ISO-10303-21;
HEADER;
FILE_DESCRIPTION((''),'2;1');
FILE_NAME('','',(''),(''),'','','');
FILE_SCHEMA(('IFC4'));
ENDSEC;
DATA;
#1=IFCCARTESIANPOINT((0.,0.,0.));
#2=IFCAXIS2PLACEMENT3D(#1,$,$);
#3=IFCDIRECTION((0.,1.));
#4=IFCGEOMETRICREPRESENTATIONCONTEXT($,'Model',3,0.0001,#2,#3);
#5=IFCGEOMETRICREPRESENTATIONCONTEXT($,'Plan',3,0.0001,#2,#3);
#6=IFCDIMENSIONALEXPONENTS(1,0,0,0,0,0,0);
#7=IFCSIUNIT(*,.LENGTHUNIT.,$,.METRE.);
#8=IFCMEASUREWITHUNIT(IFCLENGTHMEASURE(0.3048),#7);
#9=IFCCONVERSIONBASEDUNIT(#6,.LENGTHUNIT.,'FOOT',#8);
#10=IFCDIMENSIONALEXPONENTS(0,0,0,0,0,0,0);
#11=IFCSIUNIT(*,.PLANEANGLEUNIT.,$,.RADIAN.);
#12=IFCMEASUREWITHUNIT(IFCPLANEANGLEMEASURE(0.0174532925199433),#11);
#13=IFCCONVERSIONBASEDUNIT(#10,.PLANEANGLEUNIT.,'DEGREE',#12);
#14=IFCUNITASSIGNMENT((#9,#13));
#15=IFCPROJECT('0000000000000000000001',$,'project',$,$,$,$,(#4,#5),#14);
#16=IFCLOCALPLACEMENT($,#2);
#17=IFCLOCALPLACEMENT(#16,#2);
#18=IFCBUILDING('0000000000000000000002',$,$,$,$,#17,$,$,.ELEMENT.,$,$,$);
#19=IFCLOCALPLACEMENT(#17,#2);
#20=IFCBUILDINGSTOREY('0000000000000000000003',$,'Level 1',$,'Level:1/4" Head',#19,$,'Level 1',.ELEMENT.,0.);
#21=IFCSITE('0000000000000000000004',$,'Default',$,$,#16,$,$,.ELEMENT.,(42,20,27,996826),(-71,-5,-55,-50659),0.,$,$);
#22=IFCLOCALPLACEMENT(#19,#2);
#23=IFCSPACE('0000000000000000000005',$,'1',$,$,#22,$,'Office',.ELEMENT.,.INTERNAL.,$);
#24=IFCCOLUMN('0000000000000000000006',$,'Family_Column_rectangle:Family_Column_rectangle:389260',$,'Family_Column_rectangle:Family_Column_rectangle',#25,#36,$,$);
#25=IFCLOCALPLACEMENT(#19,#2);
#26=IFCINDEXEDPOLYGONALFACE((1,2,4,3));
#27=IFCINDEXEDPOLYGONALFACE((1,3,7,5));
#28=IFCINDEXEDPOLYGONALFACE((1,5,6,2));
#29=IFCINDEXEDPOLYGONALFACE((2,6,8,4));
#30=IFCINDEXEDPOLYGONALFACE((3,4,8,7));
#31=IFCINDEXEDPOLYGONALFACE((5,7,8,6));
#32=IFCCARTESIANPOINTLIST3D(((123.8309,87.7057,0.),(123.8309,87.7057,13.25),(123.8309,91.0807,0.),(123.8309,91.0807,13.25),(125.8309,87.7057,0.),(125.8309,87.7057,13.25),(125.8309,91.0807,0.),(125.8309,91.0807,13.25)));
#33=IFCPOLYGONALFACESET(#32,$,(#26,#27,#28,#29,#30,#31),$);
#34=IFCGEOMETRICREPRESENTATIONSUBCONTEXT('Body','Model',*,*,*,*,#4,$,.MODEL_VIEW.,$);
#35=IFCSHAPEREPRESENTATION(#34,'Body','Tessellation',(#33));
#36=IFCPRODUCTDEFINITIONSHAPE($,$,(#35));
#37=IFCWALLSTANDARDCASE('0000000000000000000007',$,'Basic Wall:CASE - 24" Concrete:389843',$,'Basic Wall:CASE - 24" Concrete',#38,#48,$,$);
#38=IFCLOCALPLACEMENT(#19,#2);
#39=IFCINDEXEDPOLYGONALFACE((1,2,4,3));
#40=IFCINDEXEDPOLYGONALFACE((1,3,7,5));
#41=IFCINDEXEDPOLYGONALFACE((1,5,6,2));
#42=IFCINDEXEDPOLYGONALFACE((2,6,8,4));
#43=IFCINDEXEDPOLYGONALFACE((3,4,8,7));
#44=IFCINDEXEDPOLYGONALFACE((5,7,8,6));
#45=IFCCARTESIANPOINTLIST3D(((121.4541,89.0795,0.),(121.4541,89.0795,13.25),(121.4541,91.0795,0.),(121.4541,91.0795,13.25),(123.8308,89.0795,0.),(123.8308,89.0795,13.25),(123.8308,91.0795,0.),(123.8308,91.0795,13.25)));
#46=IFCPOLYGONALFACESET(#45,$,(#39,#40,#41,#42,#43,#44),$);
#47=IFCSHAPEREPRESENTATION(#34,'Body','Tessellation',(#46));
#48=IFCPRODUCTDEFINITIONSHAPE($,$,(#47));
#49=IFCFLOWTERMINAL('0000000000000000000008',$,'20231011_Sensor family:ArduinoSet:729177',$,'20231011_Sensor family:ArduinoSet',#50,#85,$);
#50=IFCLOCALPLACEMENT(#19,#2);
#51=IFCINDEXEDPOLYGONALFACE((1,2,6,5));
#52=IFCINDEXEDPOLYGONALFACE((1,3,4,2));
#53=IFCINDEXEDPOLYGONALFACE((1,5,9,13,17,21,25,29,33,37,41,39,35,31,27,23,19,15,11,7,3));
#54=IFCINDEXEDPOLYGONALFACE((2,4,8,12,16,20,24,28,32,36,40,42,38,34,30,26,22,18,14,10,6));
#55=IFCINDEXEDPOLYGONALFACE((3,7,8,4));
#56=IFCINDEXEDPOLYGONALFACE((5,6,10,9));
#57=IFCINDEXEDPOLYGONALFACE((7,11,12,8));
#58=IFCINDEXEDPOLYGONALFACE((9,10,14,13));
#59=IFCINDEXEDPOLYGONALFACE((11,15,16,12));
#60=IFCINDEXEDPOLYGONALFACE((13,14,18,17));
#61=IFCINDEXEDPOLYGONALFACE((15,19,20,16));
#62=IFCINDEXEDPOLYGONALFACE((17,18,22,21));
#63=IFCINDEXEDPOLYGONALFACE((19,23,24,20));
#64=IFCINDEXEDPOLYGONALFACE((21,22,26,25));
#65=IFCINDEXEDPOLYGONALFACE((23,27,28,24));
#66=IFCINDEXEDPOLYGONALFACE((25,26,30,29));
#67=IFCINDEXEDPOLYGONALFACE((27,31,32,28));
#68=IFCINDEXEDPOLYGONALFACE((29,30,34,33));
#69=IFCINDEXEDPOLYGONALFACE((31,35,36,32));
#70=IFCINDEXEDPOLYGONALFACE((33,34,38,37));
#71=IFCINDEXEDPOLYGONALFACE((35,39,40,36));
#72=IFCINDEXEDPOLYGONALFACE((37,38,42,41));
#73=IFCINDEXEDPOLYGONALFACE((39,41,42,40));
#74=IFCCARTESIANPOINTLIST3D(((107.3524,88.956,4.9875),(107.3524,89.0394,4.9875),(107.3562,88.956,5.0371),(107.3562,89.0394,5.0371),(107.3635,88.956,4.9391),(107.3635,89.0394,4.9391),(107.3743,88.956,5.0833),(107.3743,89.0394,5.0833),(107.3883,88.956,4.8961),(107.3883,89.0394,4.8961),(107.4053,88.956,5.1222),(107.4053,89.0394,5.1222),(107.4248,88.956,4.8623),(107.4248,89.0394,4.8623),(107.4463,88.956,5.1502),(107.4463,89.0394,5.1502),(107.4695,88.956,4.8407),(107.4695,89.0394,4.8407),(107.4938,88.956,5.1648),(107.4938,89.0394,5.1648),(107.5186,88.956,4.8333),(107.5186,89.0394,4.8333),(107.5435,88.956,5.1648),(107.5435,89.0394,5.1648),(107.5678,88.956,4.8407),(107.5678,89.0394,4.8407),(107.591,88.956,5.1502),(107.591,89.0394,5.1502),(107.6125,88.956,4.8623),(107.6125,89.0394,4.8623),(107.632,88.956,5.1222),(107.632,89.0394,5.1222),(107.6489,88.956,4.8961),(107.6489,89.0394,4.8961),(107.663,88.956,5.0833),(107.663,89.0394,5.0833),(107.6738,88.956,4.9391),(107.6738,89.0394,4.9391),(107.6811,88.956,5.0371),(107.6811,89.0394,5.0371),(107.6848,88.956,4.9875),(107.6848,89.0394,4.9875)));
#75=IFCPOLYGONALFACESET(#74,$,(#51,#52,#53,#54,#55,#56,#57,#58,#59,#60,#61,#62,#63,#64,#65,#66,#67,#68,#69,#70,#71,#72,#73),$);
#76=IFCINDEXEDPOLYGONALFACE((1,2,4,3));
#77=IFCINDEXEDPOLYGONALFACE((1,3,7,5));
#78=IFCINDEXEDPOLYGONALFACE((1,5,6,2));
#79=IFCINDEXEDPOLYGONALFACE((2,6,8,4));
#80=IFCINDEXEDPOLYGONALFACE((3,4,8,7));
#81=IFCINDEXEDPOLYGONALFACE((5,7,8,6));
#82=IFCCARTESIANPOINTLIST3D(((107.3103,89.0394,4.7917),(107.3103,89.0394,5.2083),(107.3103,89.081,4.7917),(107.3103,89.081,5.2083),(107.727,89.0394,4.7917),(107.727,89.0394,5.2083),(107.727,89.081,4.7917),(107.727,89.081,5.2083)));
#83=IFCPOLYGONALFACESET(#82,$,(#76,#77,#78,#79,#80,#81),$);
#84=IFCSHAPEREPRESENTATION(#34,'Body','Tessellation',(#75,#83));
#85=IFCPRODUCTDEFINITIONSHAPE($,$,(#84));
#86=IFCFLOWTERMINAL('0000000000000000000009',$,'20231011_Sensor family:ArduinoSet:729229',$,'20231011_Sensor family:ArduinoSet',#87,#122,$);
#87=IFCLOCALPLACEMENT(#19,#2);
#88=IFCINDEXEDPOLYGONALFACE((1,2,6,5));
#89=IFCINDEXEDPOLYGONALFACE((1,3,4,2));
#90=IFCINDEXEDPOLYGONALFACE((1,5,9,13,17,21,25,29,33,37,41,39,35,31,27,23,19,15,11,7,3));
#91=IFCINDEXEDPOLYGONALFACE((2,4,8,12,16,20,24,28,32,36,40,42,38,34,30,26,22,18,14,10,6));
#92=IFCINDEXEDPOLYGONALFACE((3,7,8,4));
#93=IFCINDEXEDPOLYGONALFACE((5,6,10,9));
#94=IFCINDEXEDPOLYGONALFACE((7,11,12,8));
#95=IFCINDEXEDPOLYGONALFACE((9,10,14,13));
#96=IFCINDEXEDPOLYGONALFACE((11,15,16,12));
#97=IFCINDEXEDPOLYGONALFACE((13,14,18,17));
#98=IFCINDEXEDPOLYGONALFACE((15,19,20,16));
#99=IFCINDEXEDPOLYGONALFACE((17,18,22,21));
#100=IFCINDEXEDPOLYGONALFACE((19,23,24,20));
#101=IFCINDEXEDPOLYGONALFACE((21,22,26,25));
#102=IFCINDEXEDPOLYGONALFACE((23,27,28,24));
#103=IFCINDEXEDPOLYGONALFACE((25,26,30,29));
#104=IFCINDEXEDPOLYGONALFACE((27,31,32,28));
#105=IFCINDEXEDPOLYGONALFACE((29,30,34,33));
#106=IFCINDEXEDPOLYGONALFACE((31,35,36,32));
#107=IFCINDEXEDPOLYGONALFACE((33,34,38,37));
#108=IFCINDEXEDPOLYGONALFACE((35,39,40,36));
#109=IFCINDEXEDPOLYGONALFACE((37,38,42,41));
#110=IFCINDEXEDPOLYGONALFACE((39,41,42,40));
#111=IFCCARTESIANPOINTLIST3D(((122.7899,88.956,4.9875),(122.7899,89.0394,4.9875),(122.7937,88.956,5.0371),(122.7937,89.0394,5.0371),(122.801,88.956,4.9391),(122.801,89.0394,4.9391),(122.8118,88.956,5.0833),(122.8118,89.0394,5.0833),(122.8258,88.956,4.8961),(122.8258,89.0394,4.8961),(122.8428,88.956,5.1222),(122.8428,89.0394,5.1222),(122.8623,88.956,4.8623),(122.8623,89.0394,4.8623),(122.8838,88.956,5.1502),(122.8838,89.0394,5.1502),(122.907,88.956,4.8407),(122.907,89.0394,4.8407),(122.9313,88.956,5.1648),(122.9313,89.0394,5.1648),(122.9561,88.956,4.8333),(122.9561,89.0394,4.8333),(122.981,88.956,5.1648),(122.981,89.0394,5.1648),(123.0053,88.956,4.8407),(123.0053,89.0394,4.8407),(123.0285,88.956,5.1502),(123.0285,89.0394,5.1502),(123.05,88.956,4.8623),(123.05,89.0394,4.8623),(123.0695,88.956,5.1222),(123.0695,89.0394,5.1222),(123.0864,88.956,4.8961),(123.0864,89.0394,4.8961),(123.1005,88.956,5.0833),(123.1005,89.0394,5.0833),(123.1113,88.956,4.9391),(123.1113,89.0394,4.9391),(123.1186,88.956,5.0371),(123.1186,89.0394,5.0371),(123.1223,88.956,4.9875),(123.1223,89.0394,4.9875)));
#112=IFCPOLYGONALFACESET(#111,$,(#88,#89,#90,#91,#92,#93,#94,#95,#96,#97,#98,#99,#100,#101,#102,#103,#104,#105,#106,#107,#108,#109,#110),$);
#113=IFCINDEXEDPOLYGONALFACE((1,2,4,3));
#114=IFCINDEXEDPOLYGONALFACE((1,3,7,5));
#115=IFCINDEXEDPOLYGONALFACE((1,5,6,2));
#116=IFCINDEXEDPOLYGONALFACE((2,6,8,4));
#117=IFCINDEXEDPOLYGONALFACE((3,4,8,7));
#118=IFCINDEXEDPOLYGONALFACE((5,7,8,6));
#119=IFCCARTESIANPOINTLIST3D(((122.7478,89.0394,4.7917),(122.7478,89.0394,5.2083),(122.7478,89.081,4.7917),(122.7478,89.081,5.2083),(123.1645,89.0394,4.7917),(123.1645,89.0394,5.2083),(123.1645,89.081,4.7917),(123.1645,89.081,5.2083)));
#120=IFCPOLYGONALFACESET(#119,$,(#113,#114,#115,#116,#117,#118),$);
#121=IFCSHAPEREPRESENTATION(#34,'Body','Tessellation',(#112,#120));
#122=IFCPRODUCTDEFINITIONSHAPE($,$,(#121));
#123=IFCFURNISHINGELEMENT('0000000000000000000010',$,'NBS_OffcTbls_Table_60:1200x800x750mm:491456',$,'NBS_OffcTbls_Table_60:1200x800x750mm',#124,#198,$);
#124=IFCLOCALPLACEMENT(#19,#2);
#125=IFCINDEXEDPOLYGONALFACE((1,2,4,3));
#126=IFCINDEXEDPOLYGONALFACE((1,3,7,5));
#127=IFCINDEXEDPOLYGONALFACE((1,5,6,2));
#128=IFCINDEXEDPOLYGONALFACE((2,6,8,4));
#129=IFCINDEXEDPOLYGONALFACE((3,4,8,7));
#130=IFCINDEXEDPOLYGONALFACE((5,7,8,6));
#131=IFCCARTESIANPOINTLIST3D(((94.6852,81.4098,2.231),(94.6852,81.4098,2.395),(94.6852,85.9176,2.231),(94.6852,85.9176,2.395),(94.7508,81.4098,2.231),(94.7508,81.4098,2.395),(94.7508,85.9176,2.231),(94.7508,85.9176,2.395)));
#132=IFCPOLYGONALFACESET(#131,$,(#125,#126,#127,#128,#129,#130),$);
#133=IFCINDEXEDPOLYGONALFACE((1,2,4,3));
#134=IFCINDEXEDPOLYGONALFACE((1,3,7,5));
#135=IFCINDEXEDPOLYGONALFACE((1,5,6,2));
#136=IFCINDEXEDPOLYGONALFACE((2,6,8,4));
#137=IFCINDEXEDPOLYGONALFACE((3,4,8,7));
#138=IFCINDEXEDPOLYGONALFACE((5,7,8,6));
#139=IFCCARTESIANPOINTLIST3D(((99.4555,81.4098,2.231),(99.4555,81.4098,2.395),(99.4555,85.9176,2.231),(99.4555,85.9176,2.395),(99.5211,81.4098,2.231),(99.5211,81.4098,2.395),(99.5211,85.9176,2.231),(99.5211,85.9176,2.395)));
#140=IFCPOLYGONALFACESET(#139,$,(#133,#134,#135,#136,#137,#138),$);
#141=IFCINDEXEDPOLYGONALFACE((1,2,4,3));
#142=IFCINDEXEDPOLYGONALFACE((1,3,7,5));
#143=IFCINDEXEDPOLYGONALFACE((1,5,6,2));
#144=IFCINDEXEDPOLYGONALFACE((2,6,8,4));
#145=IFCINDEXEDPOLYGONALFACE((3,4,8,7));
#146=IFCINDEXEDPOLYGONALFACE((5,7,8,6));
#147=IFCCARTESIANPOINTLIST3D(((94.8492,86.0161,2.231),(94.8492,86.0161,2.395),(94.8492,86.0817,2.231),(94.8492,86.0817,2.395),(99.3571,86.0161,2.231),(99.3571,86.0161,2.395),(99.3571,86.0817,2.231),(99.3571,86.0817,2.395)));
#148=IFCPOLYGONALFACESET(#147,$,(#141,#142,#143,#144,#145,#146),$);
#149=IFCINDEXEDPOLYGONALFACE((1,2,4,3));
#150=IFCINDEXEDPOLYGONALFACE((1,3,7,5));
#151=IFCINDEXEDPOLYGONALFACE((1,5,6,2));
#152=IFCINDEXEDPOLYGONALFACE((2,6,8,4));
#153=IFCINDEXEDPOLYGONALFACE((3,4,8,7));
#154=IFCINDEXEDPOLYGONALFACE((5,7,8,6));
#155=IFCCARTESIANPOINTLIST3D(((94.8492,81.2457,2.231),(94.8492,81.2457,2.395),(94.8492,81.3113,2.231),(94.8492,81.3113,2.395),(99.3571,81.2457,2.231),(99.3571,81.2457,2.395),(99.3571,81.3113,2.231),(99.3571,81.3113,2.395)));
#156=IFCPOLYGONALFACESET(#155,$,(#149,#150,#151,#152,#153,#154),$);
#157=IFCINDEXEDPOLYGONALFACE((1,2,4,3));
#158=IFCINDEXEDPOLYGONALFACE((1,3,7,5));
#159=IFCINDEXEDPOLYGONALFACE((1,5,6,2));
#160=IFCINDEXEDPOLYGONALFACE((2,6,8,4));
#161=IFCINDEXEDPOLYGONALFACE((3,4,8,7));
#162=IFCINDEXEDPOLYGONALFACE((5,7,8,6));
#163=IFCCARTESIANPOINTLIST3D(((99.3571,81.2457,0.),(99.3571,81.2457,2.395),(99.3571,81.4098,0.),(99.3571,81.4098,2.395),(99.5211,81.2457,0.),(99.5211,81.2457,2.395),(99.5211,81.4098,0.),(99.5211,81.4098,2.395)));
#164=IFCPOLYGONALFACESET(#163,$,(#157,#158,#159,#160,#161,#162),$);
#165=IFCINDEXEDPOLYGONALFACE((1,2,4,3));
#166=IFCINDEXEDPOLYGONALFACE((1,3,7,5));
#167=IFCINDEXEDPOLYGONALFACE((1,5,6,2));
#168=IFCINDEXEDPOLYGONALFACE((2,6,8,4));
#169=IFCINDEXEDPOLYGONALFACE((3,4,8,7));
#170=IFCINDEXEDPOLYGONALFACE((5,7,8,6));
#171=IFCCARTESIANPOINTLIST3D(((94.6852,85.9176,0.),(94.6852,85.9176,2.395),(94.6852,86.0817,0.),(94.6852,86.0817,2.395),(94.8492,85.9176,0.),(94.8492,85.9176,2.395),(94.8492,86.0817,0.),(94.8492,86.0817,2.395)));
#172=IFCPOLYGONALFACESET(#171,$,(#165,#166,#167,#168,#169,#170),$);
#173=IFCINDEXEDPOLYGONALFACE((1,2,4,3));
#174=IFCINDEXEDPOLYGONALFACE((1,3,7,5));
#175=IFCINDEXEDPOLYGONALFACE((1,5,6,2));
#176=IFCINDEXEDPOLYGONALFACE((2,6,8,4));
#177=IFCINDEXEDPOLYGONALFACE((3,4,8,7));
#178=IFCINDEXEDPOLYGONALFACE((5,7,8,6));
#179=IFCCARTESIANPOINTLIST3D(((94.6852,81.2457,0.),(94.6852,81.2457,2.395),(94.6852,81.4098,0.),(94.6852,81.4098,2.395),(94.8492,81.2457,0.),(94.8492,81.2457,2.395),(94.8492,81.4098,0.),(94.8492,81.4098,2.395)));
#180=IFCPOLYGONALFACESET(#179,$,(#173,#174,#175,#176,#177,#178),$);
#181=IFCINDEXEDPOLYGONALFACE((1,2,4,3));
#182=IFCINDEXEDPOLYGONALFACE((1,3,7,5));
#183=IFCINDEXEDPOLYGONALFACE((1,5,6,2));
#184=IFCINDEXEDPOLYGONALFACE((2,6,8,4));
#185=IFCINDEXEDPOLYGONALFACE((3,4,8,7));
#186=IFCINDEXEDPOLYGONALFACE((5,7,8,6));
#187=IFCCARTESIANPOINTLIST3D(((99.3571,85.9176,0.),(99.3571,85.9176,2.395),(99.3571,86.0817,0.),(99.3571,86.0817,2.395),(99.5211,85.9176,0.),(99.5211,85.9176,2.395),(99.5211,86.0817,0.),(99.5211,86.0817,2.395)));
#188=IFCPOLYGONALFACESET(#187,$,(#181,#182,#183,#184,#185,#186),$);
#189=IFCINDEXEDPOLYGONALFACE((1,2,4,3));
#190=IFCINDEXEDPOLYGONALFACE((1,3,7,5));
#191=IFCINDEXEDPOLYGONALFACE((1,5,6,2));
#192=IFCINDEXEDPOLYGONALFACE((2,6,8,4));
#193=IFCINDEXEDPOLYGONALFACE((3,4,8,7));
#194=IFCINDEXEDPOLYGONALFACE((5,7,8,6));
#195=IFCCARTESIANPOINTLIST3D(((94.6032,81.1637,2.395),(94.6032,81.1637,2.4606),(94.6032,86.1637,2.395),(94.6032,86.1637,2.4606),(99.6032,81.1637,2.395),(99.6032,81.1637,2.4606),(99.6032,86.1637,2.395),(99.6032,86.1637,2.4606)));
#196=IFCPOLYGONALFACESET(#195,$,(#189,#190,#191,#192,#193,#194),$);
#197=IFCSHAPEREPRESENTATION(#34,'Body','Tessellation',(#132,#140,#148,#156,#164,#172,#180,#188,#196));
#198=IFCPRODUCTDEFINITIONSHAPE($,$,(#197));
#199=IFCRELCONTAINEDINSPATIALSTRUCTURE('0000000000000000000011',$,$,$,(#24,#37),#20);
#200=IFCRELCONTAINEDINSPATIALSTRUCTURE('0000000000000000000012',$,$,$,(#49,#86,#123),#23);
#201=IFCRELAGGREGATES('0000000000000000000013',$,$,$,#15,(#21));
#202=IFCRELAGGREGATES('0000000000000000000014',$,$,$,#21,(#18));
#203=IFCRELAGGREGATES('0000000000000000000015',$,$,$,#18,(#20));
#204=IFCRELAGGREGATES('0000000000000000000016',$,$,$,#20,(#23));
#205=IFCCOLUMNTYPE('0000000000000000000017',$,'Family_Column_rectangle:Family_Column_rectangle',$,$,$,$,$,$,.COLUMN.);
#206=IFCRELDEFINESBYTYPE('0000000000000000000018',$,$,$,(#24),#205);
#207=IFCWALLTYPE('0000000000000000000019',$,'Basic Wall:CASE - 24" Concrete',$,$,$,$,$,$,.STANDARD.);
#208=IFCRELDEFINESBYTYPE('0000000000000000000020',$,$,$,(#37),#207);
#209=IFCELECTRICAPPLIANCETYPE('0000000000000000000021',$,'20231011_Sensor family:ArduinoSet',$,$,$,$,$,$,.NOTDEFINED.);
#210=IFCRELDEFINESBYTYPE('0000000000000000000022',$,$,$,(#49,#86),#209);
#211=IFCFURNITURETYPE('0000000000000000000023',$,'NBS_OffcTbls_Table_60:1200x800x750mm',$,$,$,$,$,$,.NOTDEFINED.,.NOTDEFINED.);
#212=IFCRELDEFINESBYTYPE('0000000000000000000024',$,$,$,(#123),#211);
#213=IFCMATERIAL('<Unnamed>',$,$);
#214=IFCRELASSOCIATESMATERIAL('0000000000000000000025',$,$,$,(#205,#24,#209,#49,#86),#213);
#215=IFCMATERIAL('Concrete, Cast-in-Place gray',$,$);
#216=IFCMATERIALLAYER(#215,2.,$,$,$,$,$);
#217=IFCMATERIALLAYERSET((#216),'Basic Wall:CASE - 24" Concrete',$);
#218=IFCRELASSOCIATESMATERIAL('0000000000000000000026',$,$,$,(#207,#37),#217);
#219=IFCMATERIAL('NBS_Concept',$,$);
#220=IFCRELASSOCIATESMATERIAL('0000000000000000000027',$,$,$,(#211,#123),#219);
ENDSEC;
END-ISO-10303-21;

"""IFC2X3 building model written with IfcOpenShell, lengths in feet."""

from ifc_helpers import new_model, entity, si_unit, converted_unit, direction, frame, frame_2d, origin, origin_2d_with_axis, place, context, subcontext, project, spatial, rectangle, circle, extrude, source, transform, mapped, material, layer, layer_set, layer_usage, type_object, type_shapes, element, save


model = new_model("IFC2X3")

# Units and contexts
model_context = context("Model", 3, precision=0.0001, world=origin(), true_north=direction((0.0, 1.0)))
plan_context = context("Plan", 3, precision=0.0001, world=origin(), true_north=direction((0.0, 1.0)))
body_context = subcontext(model_context, "Body", "Model", "MODEL_VIEW")
ifc_project = project(units=[converted_unit("LENGTHUNIT", "FOOT", entity("IfcLengthMeasure", 0.3048), si_unit("LENGTHUNIT", "METRE"), dimensions=[1, 0, 0, 0, 0, 0, 0]), converted_unit("PLANEANGLEUNIT", "DEGREE", entity("IfcPlaneAngleMeasure", 0.0174532925199433), si_unit("PLANEANGLEUNIT", "RADIAN"), dimensions=[0, 0, 0, 0, 0, 0, 0])], contexts=[model_context, plan_context])

# Site, building, storey
site_placement = place(None, origin())
site = spatial("IfcSite", under=ifc_project, at=site_placement, Name="Default", CompositionType="ELEMENT", RefLatitude=(42, 20, 27, 996826), RefLongitude=(-71, -5, -55, -50659), RefElevation=0.0)
building_placement = place(site_placement, origin())
building = spatial("IfcBuilding", under=site, at=building_placement, CompositionType="ELEMENT")
storey_placement = place(building_placement, origin())
storey = spatial("IfcBuildingStorey", under=building, at=storey_placement, Name="Level 1", ObjectType="Level:1/4\" Head", LongName="Level 1", CompositionType="ELEMENT", Elevation=0.0)

# Column
ifc_material_1 = material(Name="<Unnamed>")
column_type = type_object("IfcColumnType", Name="Family_Column_rectangle:Family_Column_rectangle", PredefinedType="COLUMN", material=ifc_material_1)
shared_shape_1 = source(origin(), body_context, "Body", "SweptSolid", [
    extrude(rectangle(XDim=3.375, YDim=2.0, at=frame_2d((0.0, 0.0), x_axis=(1.0, 0.0))), frame((0.0, 0.0, 0.0), z_axis=(0.0, 0.0, 1.0), x_axis=(-1.0, 0.0, 0.0)), (0.0, 0.0, 1.0), 13.25),
])
type_shapes(column_type, [shared_shape_1])
column_placement = place(storey_placement, frame((124.8309, 89.3932, 0.0), z_axis=(0.0, 0.0, 1.0), x_axis=(0.0, 1.0, 0.0)))
element("IfcColumn", 1, at=column_placement, inside=storey, type_object=column_type, material=ifc_material_1, Name="Family_Column_rectangle:Family_Column_rectangle:389260", ObjectType="Family_Column_rectangle:Family_Column_rectangle", context=body_context, shape_type="MappedRepresentation", body=[
    mapped(shared_shape_1, transform((0.0, 0.0, 0.0), scale=1.0)),
])

# Wall
ifc_material_2 = material(Name="Concrete, Cast-in-Place gray")
ifc_layer = layer(ifc_material_2, 2.0)
ifc_layer_set = layer_set([ifc_layer], Name="Basic Wall:CASE - 24\" Concrete")
ifc_layer_usage = layer_usage(ifc_layer_set, "AXIS2", "NEGATIVE", 1.0)
wall_type = type_object("IfcWallType", Name="Basic Wall:CASE - 24\" Concrete", PredefinedType="STANDARD", material=ifc_layer_set)
wall_placement = place(storey_placement, frame((121.4541, 90.0795, 0.0)))
element("IfcWallStandardCase", 2, at=wall_placement, inside=storey, type_object=wall_type, material=ifc_layer_usage, Name="Basic Wall:CASE - 24\" Concrete:389843", ObjectType="Basic Wall:CASE - 24\" Concrete", context=body_context, shape_type="SweptSolid", body=[
    extrude(rectangle(XDim=2.3767, YDim=2.0, at=frame_2d((1.1884, 0.0), x_axis=(-1.0, 0.0))), origin(), (0.0, 0.0, 1.0), 13.25),
])

# Shared definitions
space_placement = place(storey_placement, origin())
space = spatial("IfcSpace", under=storey, at=space_placement, Name="1", LongName="Office", CompositionType="ELEMENT", InteriorOrExteriorSpace="INTERNAL")

# Flow terminals
electric_appliance_type = type_object("IfcElectricApplianceType", Name="20231011_Sensor family:ArduinoSet", PredefinedType="NOTDEFINED", material=ifc_material_1)
shared_shape_2 = source(origin(), body_context, "Body", "SweptSolid", [
    extrude(circle(Radius=0.1667, at=frame_2d((0.0, 0.0), x_axis=(1.0, 0.0))), frame((0.0417, 0.0, 0.0), z_axis=(1.0, 0.0, 0.0), x_axis=(0.0, 0.0, -1.0)), (0.0, 0.0, 1.0), 0.0833),
    extrude(rectangle(XDim=0.0417, YDim=0.4167, at=origin_2d_with_axis()), frame((0.0208, 0.0, -0.2083), z_axis=(0.0, 0.0, 1.0), x_axis=(-1.0, 0.0, 0.0)), (0.0, 0.0, 1.0), 0.4167),
])
type_shapes(electric_appliance_type, [shared_shape_2])
for number, where, z_axis, x_axis, name in (
    (3, (107.5186, 89.081, 5.0), (0.0, 0.0, 1.0), (0.0, -1.0, 0.0), "20231011_Sensor family:ArduinoSet:729177"),
    (4, (122.9561, 89.081, 5.0), (0.0, 0.0, 1.0), (0.0, -1.0, 0.0), "20231011_Sensor family:ArduinoSet:729229"),
):
    element("IfcFlowTerminal", number, at=place(space_placement, frame(where, z_axis=z_axis, x_axis=x_axis)), inside=space, type_object=electric_appliance_type, material=ifc_material_1, Name=name, ObjectType="20231011_Sensor family:ArduinoSet", context=body_context, shape_type="MappedRepresentation", body=[
        mapped(shared_shape_2, transform((0.0, 0.0, 0.0), scale=1.0)),
    ])

# Furnishing element
ifc_material_3 = material(Name="NBS_Concept")
furniture_type_1 = type_object("IfcFurnitureType", Name="NBS_OffcTbls_Table_60:1200x800x750mm", AssemblyPlace="NOTDEFINED", material=ifc_material_3)
shared_shape_3 = source(origin(), body_context, "Body", "SweptSolid", [
    extrude(rectangle(XDim=0.0656, YDim=4.5079, at=origin_2d_with_axis()), frame((-2.3852, 0.0, 2.231)), (0.0, 0.0, 1.0), 0.164),
    extrude(rectangle(XDim=4.5079, YDim=0.0656, at=frame_2d((0.0, 0.0), x_axis=(1.0, 0.0))), frame((2.3852, 0.0, 2.231), z_axis=(0.0, 0.0, 1.0), x_axis=(0.0, -1.0, 0.0)), (0.0, 0.0, 1.0), 0.164),
    extrude(rectangle(XDim=4.5079, YDim=0.0656, at=origin_2d_with_axis()), frame((0.0, 2.3852, 2.231), z_axis=(0.0, 0.0, 1.0), x_axis=(-1.0, 0.0, 0.0)), (0.0, 0.0, 1.0), 0.164),
    extrude(rectangle(XDim=4.5079, YDim=0.0656, at=origin_2d_with_axis()), frame((0.0, -2.3852, 2.231)), (0.0, 0.0, 1.0), 0.164),
    extrude(rectangle(XDim=0.164, YDim=0.164, at=origin_2d_with_axis()), frame((2.336, -2.336, 0.0), z_axis=(0.0, 0.0, 1.0), x_axis=(-1.0, 0.0, 0.0)), (0.0, 0.0, 1.0), 2.395),
    extrude(rectangle(XDim=0.164, YDim=0.164, at=origin_2d_with_axis()), frame((-2.336, 2.336, 0.0), z_axis=(0.0, 0.0, 1.0), x_axis=(-1.0, 0.0, 0.0)), (0.0, 0.0, 1.0), 2.395),
    extrude(rectangle(XDim=0.164, YDim=0.164, at=frame_2d((0.0, 0.0), x_axis=(1.0, 0.0))), frame((-2.336, -2.336, 0.0), z_axis=(0.0, 0.0, 1.0), x_axis=(-1.0, 0.0, 0.0)), (0.0, 0.0, 1.0), 2.395),
    extrude(rectangle(XDim=0.164, YDim=0.164, at=origin_2d_with_axis()), frame((2.336, 2.336, 0.0)), (0.0, 0.0, 1.0), 2.395),
    extrude(rectangle(XDim=5.0, YDim=5.0, at=origin_2d_with_axis()), frame((0.0, 0.0, 2.395)), (0.0, 0.0, 1.0), 0.0656),
])
type_shapes(furniture_type_1, [shared_shape_3])
furnishing_placement = place(space_placement, frame((97.1032, 83.6637, 0.0)))
element("IfcFurnishingElement", 5, at=furnishing_placement, inside=space, type_object=furniture_type_1, material=ifc_material_3, Name="NBS_OffcTbls_Table_60:1200x800x750mm:491456", ObjectType="NBS_OffcTbls_Table_60:1200x800x750mm", context=body_context, shape_type="MappedRepresentation", body=[
    mapped(shared_shape_3, transform((0.0, 0.0, 0.0), scale=1.0)),
])

save(model, "model.ifc")
